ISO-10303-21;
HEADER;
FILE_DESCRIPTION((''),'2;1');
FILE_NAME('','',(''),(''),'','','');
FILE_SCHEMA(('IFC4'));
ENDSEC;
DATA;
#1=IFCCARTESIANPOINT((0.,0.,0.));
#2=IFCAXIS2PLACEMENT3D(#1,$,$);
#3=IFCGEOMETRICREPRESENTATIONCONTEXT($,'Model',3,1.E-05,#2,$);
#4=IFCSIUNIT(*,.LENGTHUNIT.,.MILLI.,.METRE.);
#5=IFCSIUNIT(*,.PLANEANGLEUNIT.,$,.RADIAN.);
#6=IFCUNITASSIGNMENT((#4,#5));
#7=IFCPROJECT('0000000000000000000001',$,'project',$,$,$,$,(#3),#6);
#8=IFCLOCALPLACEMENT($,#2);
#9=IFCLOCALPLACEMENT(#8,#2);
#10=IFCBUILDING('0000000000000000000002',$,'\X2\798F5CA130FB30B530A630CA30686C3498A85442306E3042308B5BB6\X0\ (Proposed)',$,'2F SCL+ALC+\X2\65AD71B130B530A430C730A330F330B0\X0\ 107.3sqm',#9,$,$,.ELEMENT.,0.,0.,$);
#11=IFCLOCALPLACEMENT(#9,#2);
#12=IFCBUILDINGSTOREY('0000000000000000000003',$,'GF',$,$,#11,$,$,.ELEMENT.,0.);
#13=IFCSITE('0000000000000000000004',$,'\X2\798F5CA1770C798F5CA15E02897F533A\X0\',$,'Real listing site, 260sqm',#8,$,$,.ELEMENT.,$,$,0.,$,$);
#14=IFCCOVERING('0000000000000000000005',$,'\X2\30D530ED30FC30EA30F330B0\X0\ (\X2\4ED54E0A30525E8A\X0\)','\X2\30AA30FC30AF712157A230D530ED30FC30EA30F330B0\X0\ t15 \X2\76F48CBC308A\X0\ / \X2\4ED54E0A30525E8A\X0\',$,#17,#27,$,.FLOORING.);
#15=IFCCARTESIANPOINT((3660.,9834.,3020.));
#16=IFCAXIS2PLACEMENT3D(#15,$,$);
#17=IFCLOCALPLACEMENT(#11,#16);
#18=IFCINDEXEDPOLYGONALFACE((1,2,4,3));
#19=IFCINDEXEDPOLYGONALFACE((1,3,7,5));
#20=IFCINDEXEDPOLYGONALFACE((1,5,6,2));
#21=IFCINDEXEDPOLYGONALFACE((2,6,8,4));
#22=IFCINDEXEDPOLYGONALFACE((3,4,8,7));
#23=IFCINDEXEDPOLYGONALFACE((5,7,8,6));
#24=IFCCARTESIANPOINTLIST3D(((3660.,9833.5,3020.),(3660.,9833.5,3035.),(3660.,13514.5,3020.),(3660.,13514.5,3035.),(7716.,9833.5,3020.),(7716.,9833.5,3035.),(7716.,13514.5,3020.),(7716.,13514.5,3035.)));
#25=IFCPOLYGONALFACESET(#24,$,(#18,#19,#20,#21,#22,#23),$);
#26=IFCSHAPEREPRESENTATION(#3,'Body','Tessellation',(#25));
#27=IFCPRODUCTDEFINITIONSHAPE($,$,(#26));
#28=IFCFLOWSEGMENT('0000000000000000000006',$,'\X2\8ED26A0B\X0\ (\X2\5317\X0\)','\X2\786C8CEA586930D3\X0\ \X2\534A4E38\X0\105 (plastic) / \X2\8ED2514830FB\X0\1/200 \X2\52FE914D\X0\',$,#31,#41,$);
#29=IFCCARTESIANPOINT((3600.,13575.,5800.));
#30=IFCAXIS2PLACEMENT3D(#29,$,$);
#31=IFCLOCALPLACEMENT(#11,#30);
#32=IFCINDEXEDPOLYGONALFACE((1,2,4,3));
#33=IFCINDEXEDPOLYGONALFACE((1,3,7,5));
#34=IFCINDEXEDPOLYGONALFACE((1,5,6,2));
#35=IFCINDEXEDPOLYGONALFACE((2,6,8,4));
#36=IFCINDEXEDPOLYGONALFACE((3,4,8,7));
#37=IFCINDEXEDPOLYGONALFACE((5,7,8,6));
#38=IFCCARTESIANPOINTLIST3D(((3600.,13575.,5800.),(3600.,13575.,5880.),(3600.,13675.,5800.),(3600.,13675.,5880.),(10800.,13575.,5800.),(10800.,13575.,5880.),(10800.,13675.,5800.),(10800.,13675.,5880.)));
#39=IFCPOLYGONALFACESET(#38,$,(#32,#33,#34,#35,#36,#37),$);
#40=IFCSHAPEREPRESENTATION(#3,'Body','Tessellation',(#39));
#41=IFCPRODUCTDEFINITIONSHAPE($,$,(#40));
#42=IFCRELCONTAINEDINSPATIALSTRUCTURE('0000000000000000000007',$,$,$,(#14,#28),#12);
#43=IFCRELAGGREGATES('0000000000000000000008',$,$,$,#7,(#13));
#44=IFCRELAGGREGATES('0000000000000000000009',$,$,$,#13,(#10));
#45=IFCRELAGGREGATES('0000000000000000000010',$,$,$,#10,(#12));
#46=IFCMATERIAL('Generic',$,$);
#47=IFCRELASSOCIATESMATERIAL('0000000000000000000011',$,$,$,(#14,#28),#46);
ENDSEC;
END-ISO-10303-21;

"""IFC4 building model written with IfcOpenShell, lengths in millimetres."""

from ifc_helpers import new_model, si_unit, frame, frame_2d, origin, place, context, project, spatial, rectangle, extrude, material, element, save


model = new_model("IFC4")

# Units and contexts
model_context = context("Model", 3, precision=1e-05, world=origin())
ifc_project = project(units=[si_unit("LENGTHUNIT", "METRE", prefix="MILLI"), si_unit("PLANEANGLEUNIT", "RADIAN")], contexts=[model_context])

# Site, building, storey
site_placement = place(None, origin())
site = spatial("IfcSite", under=ifc_project, at=site_placement, Name="福岡県福岡市西区", ObjectType="Real listing site, 260sqm", CompositionType="ELEMENT", RefElevation=0.0)
building_placement = place(site_placement, origin())
building = spatial("IfcBuilding", under=site, at=building_placement, Name="福岡・サウナと水風呂のある家 (Proposed)", ObjectType="2F SCL+ALC+断熱サイディング 107.3sqm", CompositionType="ELEMENT", ElevationOfRefHeight=0.0, ElevationOfTerrain=0.0)
storey_placement = place(building_placement, origin())
storey = spatial("IfcBuildingStorey", under=building, at=storey_placement, Name="GF", CompositionType="ELEMENT", Elevation=0.0)

# Covering
ifc_material_1 = material(Name="Generic")
covering_placement = place(storey_placement, frame((3660.0, 9834.0, 3020.0)))
element("IfcCovering", 1, at=covering_placement, inside=storey, material=ifc_material_1, Name="フローリング (仕上げ床)", Description="オーク無垢フローリング t15 直貼り / 仕上げ床", PredefinedType="FLOORING", context=model_context, shape_type="SweptSolid", body=[
    extrude(rectangle(XDim=4056.0, YDim=3681.0, at=frame_2d((2028.0, 1840.0))), frame((3660.0, 9834.0, 3020.0)), (0.0, 0.0, 1.0), 15.0),
])

# Flow segment
flow_segment_placement = place(storey_placement, frame((3600.0, 13575.0, 5800.0)))
element("IfcFlowSegment", 2, at=flow_segment_placement, inside=storey, material=ifc_material_1, Name="軒樋 (北)", Description="硬質塩ビ 半丸105 (plastic) / 軒先・1/200 勾配", context=model_context, shape_type="SweptSolid", body=[
    extrude(rectangle(XDim=7200.0, YDim=100.0, at=frame_2d((3600.0, 50.0))), frame((3600.0, 13575.0, 5800.0)), (0.0, 0.0, 1.0), 80.0),
])

save(model, "model.ifc")
